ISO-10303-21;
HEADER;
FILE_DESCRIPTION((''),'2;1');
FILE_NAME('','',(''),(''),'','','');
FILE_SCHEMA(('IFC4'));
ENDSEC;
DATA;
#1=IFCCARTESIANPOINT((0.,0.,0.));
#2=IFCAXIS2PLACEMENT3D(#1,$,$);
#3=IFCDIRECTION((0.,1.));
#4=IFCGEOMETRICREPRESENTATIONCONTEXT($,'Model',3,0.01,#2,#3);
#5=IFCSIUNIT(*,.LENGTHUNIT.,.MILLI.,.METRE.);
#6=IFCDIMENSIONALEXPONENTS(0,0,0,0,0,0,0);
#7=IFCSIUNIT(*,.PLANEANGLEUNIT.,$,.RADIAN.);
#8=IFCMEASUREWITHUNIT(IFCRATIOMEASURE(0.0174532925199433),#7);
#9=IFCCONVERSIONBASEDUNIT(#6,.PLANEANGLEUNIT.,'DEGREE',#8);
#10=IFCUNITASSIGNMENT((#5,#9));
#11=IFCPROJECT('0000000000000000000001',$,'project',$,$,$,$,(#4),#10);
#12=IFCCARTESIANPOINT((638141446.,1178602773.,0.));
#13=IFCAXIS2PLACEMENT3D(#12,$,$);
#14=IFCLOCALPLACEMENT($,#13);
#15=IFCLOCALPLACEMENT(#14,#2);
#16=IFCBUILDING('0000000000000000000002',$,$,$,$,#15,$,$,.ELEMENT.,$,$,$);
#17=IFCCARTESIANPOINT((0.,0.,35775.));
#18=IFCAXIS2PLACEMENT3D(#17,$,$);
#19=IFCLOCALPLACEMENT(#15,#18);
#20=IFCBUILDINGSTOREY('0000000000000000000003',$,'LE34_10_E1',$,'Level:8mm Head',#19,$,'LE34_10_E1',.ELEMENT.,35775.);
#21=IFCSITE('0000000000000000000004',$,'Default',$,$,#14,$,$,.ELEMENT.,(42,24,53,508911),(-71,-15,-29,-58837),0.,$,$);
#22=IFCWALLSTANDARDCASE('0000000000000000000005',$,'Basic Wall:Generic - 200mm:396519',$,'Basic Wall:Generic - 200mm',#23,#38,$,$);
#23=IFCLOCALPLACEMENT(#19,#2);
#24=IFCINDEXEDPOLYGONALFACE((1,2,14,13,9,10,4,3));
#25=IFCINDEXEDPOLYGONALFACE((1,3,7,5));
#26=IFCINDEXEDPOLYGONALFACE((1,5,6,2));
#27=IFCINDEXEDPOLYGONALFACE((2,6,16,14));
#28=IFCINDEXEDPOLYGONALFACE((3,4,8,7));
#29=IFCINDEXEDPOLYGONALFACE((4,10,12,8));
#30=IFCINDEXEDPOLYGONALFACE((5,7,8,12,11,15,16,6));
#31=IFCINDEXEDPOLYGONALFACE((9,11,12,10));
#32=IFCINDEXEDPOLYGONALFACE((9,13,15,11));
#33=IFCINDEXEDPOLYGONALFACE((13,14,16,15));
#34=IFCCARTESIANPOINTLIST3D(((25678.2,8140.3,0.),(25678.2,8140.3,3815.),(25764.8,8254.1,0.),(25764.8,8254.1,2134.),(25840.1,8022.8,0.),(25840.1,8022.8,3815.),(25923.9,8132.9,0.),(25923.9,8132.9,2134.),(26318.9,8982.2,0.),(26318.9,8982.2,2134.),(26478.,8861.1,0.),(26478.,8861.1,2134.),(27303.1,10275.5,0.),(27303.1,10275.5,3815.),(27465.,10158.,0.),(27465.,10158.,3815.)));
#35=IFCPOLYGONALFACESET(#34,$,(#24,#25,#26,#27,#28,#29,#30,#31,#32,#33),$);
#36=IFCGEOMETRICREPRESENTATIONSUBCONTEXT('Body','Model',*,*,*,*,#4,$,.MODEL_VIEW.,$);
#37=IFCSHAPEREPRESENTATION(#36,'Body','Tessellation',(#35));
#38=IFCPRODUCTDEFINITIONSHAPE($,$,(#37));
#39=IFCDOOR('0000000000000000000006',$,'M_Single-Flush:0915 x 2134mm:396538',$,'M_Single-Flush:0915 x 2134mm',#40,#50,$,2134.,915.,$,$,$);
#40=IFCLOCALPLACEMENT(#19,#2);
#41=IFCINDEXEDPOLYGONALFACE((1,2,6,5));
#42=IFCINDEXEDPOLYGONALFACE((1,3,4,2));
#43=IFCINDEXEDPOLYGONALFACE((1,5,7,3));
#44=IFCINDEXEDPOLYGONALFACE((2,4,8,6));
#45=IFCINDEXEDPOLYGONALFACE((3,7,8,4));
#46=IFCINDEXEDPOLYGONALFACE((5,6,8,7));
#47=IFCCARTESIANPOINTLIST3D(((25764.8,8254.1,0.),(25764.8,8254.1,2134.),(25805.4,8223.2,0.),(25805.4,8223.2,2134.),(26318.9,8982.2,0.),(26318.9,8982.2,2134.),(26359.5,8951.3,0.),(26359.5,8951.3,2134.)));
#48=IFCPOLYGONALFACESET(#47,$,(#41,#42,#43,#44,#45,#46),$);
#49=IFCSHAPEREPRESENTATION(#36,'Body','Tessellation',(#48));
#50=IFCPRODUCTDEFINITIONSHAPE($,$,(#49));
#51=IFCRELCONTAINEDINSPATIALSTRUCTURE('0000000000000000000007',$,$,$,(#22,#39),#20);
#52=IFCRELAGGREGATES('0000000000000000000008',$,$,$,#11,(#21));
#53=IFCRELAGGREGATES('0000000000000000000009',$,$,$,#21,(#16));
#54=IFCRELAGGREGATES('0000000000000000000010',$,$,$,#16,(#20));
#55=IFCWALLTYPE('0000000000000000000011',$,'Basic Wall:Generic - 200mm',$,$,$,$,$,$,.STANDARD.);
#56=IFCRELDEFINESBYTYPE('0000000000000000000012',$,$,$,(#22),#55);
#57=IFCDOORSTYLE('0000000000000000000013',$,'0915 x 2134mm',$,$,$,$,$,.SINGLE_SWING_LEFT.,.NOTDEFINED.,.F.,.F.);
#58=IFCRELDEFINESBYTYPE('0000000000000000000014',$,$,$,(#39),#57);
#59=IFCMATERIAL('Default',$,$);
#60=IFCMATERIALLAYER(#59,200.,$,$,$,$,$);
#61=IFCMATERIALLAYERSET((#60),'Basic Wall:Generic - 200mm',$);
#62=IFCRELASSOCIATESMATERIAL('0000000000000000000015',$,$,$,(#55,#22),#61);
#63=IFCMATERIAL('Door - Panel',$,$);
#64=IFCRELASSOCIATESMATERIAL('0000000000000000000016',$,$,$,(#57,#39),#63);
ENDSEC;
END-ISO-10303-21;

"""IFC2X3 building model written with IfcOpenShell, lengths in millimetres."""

from ifc_helpers import new_model, entity, si_unit, converted_unit, direction, frame, frame_2d, origin, place, context, subcontext, project, spatial, polyline, rectangle, outline, extrude, source, transform, mapped, material, layer, layer_set, layer_usage, type_object, type_shapes, element, fill, save


model = new_model("IFC2X3")

# Units and contexts
model_context = context("Model", 3, precision=0.01, world=origin(), true_north=direction((0.0, 1.0)))
body_context = subcontext(model_context, "Body", "Model", "MODEL_VIEW")
ifc_project = project(units=[si_unit("LENGTHUNIT", "METRE", prefix="MILLI"), converted_unit("PLANEANGLEUNIT", "DEGREE", entity("IfcRatioMeasure", 0.0174532925199433), si_unit("PLANEANGLEUNIT", "RADIAN"), dimensions=[0, 0, 0, 0, 0, 0, 0])], contexts=[model_context])

# Site, building, storey
site_placement = place(None, frame((638141446.0, 1178602773.0, 0.0)))
site = spatial("IfcSite", under=ifc_project, at=site_placement, Name="Default", CompositionType="ELEMENT", RefLatitude=(42, 24, 53, 508911), RefLongitude=(-71, -15, -29, -58837), RefElevation=0.0)
building_placement = place(site_placement, origin())
building = spatial("IfcBuilding", under=site, at=building_placement, CompositionType="ELEMENT")
storey_placement = place(building_placement, frame((0.0, 0.0, 35775.0)))
storey = spatial("IfcBuildingStorey", under=building, at=storey_placement, Name="LE34_10_E1", ObjectType="Level:8mm Head", LongName="LE34_10_E1", CompositionType="ELEMENT", Elevation=35775.0)

# Shared definitions
ifc_material_1 = material(Name="Default")
ifc_material_2 = material(Name="Door - Panel")

# Wall, opening, door
ifc_layer_1 = layer(ifc_material_1, 200.0)
ifc_layer_set_1 = layer_set([ifc_layer_1], Name="Basic Wall:Generic - 200mm")
ifc_layer_usage_1 = layer_usage(ifc_layer_set_1, "AXIS2", "NEGATIVE", 100.0)
wall_type_1 = type_object("IfcWallType", Name="Basic Wall:Generic - 200mm", PredefinedType="STANDARD", material=ifc_layer_set_1)
wall_1_placement = place(storey_placement, frame((27385.5, 10218.6, 0.0), z_axis=(0.0, 0.0, 1.0), x_axis=(-0.605591, -0.795776, 0.0)))
wall_1 = element("IfcWallStandardCase", 1, at=wall_1_placement, inside=storey, type_object=wall_type_1, material=ifc_layer_usage_1, Name="Basic Wall:Generic - 200mm:396519", ObjectType="Basic Wall:Generic - 200mm", context=body_context, shape_type="SweptSolid", body=[
    extrude(outline(polyline([(4.6, -100.0), (2687.7, -100.0), (2683.2, 100.0), (0.0, 100.0), (4.6, -100.0)])), origin(), (0.0, 0.0, 1.0), 3815.0),
])
opening_1_placement = place(wall_1_placement, frame((2544.8, 100.0, 0.0)))
opening_1 = element("IfcOpeningElement", 2, at=opening_1_placement, cuts=wall_1, ObjectType="Opening", context=body_context, shape_type="SweptSolid", body=[
    extrude(rectangle(XDim=915.0, YDim=2134.0, at=frame_2d((1067.0, 457.5), x_axis=(0.0, -1.0))), frame((0.0, 0.0, 0.0), z_axis=(0.0, -1.0, 0.0), x_axis=(0.0, 0.0, 1.0)), (0.0, 0.0, 1.0), 200.0),
])
door_style_1 = type_object("IfcDoorStyle", Name="0915 x 2134mm", ConstructionType="NOTDEFINED", OperationType="SINGLE_SWING_LEFT", ParameterTakesPrecedence=False, Sizeable=False, material=ifc_material_2)
shared_shape_1 = source(origin(), body_context, "Body", "SweptSolid", [
    extrude(rectangle(XDim=915.0, YDim=51.0, at=frame_2d((0.0, 0.0), x_axis=(1.0, 0.0))), frame((457.5, 174.5, 0.0)), (0.0, 0.0, 1.0), 2134.0),
])
type_shapes(door_style_1, [shared_shape_1])
door_1_placement = place(opening_1_placement, frame((0.0, 0.0, 0.0), z_axis=(0.0, 0.0, 1.0), x_axis=(-1.0, 0.0, 0.0)))
door_1 = element("IfcDoor", 3, at=door_1_placement, inside=storey, type_object=door_style_1, material=ifc_material_2, Name="M_Single-Flush:0915 x 2134mm:396538", ObjectType="M_Single-Flush:0915 x 2134mm", OverallHeight=2134.0, OverallWidth=915.0, context=body_context, shape_type="MappedRepresentation", body=[
    mapped(shared_shape_1, transform((0.0, 0.0, 0.0), scale=1.0)),
])
fill(opening_1, door_1)

save(model, "model.ifc")
